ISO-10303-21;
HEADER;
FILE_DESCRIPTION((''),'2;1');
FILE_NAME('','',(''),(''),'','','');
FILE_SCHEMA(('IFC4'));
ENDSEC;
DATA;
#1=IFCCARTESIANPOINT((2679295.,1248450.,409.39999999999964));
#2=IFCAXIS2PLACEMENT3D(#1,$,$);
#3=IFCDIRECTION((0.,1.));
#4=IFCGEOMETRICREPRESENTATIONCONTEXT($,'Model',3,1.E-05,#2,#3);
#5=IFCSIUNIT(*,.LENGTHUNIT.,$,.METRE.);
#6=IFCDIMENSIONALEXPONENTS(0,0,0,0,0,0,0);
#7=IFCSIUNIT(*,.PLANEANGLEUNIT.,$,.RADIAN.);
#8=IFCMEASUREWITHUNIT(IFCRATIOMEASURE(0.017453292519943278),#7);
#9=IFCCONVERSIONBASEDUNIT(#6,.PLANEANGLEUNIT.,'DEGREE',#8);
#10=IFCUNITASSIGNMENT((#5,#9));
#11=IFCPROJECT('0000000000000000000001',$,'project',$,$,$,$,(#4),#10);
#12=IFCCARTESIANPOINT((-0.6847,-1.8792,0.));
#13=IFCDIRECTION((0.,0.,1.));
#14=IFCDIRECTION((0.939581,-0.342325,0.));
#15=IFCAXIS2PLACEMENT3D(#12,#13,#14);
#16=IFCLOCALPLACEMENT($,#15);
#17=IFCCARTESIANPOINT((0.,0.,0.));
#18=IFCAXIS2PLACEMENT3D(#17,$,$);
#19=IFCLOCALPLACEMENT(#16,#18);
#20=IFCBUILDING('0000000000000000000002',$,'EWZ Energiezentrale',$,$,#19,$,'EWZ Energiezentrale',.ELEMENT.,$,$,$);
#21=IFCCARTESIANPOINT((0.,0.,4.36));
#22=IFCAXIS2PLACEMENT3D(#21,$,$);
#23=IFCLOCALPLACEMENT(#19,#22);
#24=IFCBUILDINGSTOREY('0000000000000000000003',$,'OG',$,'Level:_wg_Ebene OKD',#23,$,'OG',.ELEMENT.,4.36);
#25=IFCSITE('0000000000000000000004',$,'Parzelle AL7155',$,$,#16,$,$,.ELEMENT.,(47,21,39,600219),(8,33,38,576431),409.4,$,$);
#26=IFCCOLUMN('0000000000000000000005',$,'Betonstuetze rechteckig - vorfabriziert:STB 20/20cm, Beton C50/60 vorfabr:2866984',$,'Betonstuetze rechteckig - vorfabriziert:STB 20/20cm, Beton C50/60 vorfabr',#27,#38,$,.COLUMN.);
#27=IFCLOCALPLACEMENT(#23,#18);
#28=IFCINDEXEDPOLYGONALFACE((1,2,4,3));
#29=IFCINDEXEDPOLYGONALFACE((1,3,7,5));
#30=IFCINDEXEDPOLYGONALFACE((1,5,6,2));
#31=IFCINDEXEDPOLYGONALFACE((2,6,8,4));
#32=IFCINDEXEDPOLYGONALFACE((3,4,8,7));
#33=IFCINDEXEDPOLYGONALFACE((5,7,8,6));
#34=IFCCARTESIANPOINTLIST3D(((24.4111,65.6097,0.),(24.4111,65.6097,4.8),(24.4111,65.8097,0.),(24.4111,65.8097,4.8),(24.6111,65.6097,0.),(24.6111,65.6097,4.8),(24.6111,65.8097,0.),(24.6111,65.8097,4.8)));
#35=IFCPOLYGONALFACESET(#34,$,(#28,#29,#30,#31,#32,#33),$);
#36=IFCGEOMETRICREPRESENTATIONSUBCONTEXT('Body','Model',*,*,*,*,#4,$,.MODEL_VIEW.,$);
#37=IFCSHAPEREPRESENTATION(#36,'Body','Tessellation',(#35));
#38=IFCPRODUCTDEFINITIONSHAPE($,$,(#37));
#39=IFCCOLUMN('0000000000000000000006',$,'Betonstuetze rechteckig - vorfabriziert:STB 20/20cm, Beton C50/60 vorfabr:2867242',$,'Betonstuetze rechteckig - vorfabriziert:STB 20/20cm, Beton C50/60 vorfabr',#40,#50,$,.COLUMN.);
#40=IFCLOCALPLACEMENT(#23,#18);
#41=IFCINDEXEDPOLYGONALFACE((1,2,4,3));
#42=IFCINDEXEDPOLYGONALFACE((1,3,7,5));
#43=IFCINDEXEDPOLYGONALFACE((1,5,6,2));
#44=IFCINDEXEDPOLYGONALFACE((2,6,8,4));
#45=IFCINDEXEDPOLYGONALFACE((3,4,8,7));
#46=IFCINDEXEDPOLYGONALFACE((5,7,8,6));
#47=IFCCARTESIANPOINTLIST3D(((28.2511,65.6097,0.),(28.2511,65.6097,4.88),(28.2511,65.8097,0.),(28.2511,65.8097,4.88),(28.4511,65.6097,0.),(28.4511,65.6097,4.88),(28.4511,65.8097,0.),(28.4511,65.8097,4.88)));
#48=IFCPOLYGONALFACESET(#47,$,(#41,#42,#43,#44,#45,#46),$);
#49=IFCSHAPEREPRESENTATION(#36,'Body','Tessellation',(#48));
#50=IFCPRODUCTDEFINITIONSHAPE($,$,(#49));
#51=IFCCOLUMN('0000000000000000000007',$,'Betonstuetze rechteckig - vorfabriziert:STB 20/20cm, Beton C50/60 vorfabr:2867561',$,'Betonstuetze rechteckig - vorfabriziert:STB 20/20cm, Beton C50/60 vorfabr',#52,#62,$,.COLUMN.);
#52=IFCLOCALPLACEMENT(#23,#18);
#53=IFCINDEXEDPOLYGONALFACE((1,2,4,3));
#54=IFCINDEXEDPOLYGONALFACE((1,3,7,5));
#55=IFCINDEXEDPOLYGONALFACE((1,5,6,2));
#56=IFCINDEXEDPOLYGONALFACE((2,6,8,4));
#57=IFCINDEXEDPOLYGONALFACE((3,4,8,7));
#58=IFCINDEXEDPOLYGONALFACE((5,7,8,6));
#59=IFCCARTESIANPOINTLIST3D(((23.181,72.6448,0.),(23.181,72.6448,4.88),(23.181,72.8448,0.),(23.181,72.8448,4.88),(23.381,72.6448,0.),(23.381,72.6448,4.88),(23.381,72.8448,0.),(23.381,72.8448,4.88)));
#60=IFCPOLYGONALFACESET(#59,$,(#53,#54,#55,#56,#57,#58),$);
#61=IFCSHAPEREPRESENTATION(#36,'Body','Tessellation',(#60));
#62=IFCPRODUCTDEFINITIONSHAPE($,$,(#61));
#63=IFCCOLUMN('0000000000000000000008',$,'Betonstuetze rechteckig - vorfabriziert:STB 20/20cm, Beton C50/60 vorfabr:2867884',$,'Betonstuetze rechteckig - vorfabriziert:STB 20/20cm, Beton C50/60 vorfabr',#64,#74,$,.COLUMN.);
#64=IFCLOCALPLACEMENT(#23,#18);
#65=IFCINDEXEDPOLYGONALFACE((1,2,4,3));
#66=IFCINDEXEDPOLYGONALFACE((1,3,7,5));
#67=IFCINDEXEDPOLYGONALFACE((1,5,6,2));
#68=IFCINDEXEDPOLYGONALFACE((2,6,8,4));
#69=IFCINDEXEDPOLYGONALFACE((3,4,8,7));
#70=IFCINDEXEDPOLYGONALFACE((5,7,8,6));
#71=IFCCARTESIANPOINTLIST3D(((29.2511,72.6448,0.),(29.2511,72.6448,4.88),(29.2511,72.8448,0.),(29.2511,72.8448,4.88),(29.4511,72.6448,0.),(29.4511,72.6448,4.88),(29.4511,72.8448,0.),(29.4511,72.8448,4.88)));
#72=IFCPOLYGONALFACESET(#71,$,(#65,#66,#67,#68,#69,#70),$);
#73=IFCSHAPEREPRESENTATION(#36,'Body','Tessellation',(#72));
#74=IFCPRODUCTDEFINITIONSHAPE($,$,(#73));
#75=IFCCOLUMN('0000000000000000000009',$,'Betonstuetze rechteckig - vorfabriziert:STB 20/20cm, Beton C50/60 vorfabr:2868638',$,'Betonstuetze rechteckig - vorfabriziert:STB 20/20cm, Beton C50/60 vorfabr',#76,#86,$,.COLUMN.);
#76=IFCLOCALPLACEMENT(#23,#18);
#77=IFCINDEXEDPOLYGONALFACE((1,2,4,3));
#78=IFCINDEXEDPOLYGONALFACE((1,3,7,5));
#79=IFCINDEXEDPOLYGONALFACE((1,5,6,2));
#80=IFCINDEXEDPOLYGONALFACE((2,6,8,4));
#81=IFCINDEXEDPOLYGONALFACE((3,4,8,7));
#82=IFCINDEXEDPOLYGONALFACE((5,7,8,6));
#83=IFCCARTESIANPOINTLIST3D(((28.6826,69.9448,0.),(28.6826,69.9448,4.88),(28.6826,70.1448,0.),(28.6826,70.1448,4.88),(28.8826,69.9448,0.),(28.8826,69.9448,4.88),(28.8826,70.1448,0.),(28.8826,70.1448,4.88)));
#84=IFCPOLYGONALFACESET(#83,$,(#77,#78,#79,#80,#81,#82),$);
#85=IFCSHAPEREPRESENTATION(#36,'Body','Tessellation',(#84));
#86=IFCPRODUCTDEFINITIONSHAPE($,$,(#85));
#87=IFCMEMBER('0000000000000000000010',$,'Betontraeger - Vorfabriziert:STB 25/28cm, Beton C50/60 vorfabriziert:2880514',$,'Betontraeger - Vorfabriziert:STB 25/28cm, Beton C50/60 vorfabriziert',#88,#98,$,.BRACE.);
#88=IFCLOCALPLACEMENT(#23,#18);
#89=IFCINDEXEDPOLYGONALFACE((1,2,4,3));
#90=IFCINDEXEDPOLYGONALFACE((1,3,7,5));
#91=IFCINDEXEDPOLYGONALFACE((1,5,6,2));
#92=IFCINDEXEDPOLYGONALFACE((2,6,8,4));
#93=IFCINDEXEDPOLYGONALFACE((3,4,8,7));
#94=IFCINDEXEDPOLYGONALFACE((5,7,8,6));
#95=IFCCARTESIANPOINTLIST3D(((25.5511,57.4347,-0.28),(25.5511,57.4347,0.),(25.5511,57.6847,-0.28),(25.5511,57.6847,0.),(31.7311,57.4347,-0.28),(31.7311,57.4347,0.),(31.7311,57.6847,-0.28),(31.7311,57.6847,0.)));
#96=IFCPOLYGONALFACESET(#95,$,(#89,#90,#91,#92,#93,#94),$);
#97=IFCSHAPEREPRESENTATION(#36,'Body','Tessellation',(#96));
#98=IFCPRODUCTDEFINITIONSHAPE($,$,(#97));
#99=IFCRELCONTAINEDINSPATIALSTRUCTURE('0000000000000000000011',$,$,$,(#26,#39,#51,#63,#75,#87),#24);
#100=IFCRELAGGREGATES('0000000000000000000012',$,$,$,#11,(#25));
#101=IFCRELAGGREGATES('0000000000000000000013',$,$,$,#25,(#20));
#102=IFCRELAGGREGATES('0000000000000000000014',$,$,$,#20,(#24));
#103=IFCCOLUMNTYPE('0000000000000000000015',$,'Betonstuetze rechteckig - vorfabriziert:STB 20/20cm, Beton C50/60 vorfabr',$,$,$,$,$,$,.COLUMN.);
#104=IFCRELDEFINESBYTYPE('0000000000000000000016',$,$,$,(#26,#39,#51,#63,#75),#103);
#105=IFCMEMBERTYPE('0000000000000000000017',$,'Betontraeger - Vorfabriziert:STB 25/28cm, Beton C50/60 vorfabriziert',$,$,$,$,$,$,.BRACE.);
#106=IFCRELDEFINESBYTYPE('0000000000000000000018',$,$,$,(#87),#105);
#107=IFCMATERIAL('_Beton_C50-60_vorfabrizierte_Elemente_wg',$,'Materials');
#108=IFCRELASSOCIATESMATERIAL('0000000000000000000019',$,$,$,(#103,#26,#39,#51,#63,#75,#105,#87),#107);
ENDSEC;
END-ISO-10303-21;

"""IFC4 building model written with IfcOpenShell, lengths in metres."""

from ifc_helpers import new_model, entity, si_unit, converted_unit, direction, frame, origin, place, context, subcontext, project, spatial, indexed_curve, outline, extrude, source, transform, mapped, material, type_object, type_shapes, element, save


model = new_model("IFC4")

# Units and contexts
model_context = context("Model", 3, precision=1e-05, world=frame((2679295.0, 1248450.0, 409.39999999999964)), true_north=direction((0.0, 1.0)))
body_context = subcontext(model_context, "Body", "Model", "MODEL_VIEW")
ifc_project = project(units=[si_unit("LENGTHUNIT", "METRE"), converted_unit("PLANEANGLEUNIT", "DEGREE", entity("IfcRatioMeasure", 0.017453292519943278), si_unit("PLANEANGLEUNIT", "RADIAN"), dimensions=[0, 0, 0, 0, 0, 0, 0])], contexts=[model_context])

# Site, building, storey
site_placement = place(None, frame((-0.6847, -1.8792, 0.0), z_axis=(0.0, 0.0, 1.0), x_axis=(0.939581, -0.342325, 0.0)))
site = spatial("IfcSite", under=ifc_project, at=site_placement, Name="Parzelle AL7155", CompositionType="ELEMENT", RefLatitude=(47, 21, 39, 600219), RefLongitude=(8, 33, 38, 576431), RefElevation=409.4)
building_placement = place(site_placement, origin())
building = spatial("IfcBuilding", under=site, at=building_placement, Name="EWZ Energiezentrale", LongName="EWZ Energiezentrale", CompositionType="ELEMENT")
storey_placement = place(building_placement, frame((0.0, 0.0, 4.36)))
storey = spatial("IfcBuildingStorey", under=building, at=storey_placement, Name="OG", ObjectType="Level:_wg_Ebene OKD", LongName="OG", CompositionType="ELEMENT", Elevation=4.36)

# Columns
ifc_material_1 = material(Name="_Beton_C50-60_vorfabrizierte_Elemente_wg", Category="Materials")
column_type = type_object("IfcColumnType", Name="Betonstuetze rechteckig - vorfabriziert:STB 20/20cm, Beton C50/60 vorfabr", PredefinedType="COLUMN", material=ifc_material_1)
shared_shape_1 = source(origin(), body_context, "Body", "SweptSolid", [
    extrude(outline(indexed_curve([(-0.1, -0.1), (0.1, -0.1), (0.1, 0.1), (-0.1, 0.1), (-0.1, -0.1)], self_intersect=False)), frame((24.5111, 65.7097, 4.36), z_axis=(0.0, 0.0, 1.0), x_axis=(-1.0, 0.0, 0.0)), (0.0, 0.0, 1.0), 4.8),
])
column_1_placement = place(storey_placement, frame((0.0, 0.0, -4.36)))
element("IfcColumn", 1, at=column_1_placement, inside=storey, type_object=column_type, material=ifc_material_1, Name="Betonstuetze rechteckig - vorfabriziert:STB 20/20cm, Beton C50/60 vorfabr:2866984", ObjectType="Betonstuetze rechteckig - vorfabriziert:STB 20/20cm, Beton C50/60 vorfabr", PredefinedType="COLUMN", context=body_context, shape_type="MappedRepresentation", body=[
    mapped(shared_shape_1, transform((0.0, 0.0, 0.0), scale=1.0)),
])
shared_shape_2 = source(origin(), body_context, "Body", "SweptSolid", [
    extrude(outline(indexed_curve([(-0.1, -0.1), (0.1, -0.1), (0.1, 0.1), (-0.1, 0.1), (-0.1, -0.1)], self_intersect=False)), frame((28.3511, 65.7097, 4.36), z_axis=(0.0, 0.0, 1.0), x_axis=(-1.0, 0.0, 0.0)), (0.0, 0.0, 1.0), 4.88),
])
column_2_placement = place(storey_placement, frame((0.0, 0.0, -4.36)))
element("IfcColumn", 2, at=column_2_placement, inside=storey, type_object=column_type, material=ifc_material_1, Name="Betonstuetze rechteckig - vorfabriziert:STB 20/20cm, Beton C50/60 vorfabr:2867242", ObjectType="Betonstuetze rechteckig - vorfabriziert:STB 20/20cm, Beton C50/60 vorfabr", PredefinedType="COLUMN", context=body_context, shape_type="MappedRepresentation", body=[
    mapped(shared_shape_2, transform((0.0, 0.0, 0.0), scale=1.0)),
])
shared_shape_3 = source(origin(), body_context, "Body", "SweptSolid", [
    extrude(outline(indexed_curve([(-0.1, -0.1), (0.1, -0.1), (0.1, 0.1), (-0.1, 0.1), (-0.1, -0.1)], self_intersect=False)), frame((23.281, 72.7448, 4.36), z_axis=(0.0, 0.0, 1.0), x_axis=(0.0, -1.0, 0.0)), (0.0, 0.0, 1.0), 4.88),
])
column_3_placement = place(storey_placement, frame((0.0, 0.0, -4.36)))
element("IfcColumn", 3, at=column_3_placement, inside=storey, type_object=column_type, material=ifc_material_1, Name="Betonstuetze rechteckig - vorfabriziert:STB 20/20cm, Beton C50/60 vorfabr:2867561", ObjectType="Betonstuetze rechteckig - vorfabriziert:STB 20/20cm, Beton C50/60 vorfabr", PredefinedType="COLUMN", context=body_context, shape_type="MappedRepresentation", body=[
    mapped(shared_shape_3, transform((0.0, 0.0, 0.0), scale=1.0)),
])
shared_shape_4 = source(origin(), body_context, "Body", "SweptSolid", [
    extrude(outline(indexed_curve([(-0.1, -0.1), (0.1, -0.1), (0.1, 0.1), (-0.1, 0.1), (-0.1, -0.1)], self_intersect=False)), frame((29.3511, 72.7448, 4.36), z_axis=(0.0, 0.0, 1.0), x_axis=(-1.0, 0.0, 0.0)), (0.0, 0.0, 1.0), 4.88),
])
column_4_placement = place(storey_placement, frame((0.0, 0.0, -4.36)))
element("IfcColumn", 4, at=column_4_placement, inside=storey, type_object=column_type, material=ifc_material_1, Name="Betonstuetze rechteckig - vorfabriziert:STB 20/20cm, Beton C50/60 vorfabr:2867884", ObjectType="Betonstuetze rechteckig - vorfabriziert:STB 20/20cm, Beton C50/60 vorfabr", PredefinedType="COLUMN", context=body_context, shape_type="MappedRepresentation", body=[
    mapped(shared_shape_4, transform((0.0, 0.0, 0.0), scale=1.0)),
])
shared_shape_5 = source(origin(), body_context, "Body", "SweptSolid", [
    extrude(outline(indexed_curve([(-0.1, -0.1), (0.1, -0.1), (0.1, 0.1), (-0.1, 0.1), (-0.1, -0.1)], self_intersect=False)), frame((28.7826, 70.0448, 4.36), z_axis=(0.0, 0.0, 1.0), x_axis=(0.0, -1.0, 0.0)), (0.0, 0.0, 1.0), 4.88),
])
column_5_placement = place(storey_placement, frame((0.0, 0.0, -4.36)))
element("IfcColumn", 5, at=column_5_placement, inside=storey, type_object=column_type, material=ifc_material_1, Name="Betonstuetze rechteckig - vorfabriziert:STB 20/20cm, Beton C50/60 vorfabr:2868638", ObjectType="Betonstuetze rechteckig - vorfabriziert:STB 20/20cm, Beton C50/60 vorfabr", PredefinedType="COLUMN", context=body_context, shape_type="MappedRepresentation", body=[
    mapped(shared_shape_5, transform((0.0, 0.0, 0.0), scale=1.0)),
])

# Member
member_type = type_object("IfcMemberType", Name="Betontraeger - Vorfabriziert:STB 25/28cm, Beton C50/60 vorfabriziert", PredefinedType="BRACE", material=ifc_material_1)
shared_shape_6 = source(origin(), body_context, "Body", "SweptSolid", [
    extrude(outline(indexed_curve([(-0.14, -0.125), (0.14, -0.125), (0.14, 0.125), (-0.14, 0.125), (-0.14, -0.125)], self_intersect=False)), frame((25.5511, 57.5597, 4.22), z_axis=(1.0, 0.0, 0.0), x_axis=(0.0, 0.0, -1.0)), (0.0, 0.0, 1.0), 6.1799),
])
type_shapes(member_type, [shared_shape_6])
member_placement = place(storey_placement, frame((0.0, 0.0, -4.36)))
element("IfcMember", 6, at=member_placement, inside=storey, type_object=member_type, material=ifc_material_1, Name="Betontraeger - Vorfabriziert:STB 25/28cm, Beton C50/60 vorfabriziert:2880514", ObjectType="Betontraeger - Vorfabriziert:STB 25/28cm, Beton C50/60 vorfabriziert", PredefinedType="BRACE", context=body_context, shape_type="MappedRepresentation", body=[
    mapped(shared_shape_6, transform((0.0, 0.0, 0.0), scale=1.0)),
])

save(model, "model.ifc")
